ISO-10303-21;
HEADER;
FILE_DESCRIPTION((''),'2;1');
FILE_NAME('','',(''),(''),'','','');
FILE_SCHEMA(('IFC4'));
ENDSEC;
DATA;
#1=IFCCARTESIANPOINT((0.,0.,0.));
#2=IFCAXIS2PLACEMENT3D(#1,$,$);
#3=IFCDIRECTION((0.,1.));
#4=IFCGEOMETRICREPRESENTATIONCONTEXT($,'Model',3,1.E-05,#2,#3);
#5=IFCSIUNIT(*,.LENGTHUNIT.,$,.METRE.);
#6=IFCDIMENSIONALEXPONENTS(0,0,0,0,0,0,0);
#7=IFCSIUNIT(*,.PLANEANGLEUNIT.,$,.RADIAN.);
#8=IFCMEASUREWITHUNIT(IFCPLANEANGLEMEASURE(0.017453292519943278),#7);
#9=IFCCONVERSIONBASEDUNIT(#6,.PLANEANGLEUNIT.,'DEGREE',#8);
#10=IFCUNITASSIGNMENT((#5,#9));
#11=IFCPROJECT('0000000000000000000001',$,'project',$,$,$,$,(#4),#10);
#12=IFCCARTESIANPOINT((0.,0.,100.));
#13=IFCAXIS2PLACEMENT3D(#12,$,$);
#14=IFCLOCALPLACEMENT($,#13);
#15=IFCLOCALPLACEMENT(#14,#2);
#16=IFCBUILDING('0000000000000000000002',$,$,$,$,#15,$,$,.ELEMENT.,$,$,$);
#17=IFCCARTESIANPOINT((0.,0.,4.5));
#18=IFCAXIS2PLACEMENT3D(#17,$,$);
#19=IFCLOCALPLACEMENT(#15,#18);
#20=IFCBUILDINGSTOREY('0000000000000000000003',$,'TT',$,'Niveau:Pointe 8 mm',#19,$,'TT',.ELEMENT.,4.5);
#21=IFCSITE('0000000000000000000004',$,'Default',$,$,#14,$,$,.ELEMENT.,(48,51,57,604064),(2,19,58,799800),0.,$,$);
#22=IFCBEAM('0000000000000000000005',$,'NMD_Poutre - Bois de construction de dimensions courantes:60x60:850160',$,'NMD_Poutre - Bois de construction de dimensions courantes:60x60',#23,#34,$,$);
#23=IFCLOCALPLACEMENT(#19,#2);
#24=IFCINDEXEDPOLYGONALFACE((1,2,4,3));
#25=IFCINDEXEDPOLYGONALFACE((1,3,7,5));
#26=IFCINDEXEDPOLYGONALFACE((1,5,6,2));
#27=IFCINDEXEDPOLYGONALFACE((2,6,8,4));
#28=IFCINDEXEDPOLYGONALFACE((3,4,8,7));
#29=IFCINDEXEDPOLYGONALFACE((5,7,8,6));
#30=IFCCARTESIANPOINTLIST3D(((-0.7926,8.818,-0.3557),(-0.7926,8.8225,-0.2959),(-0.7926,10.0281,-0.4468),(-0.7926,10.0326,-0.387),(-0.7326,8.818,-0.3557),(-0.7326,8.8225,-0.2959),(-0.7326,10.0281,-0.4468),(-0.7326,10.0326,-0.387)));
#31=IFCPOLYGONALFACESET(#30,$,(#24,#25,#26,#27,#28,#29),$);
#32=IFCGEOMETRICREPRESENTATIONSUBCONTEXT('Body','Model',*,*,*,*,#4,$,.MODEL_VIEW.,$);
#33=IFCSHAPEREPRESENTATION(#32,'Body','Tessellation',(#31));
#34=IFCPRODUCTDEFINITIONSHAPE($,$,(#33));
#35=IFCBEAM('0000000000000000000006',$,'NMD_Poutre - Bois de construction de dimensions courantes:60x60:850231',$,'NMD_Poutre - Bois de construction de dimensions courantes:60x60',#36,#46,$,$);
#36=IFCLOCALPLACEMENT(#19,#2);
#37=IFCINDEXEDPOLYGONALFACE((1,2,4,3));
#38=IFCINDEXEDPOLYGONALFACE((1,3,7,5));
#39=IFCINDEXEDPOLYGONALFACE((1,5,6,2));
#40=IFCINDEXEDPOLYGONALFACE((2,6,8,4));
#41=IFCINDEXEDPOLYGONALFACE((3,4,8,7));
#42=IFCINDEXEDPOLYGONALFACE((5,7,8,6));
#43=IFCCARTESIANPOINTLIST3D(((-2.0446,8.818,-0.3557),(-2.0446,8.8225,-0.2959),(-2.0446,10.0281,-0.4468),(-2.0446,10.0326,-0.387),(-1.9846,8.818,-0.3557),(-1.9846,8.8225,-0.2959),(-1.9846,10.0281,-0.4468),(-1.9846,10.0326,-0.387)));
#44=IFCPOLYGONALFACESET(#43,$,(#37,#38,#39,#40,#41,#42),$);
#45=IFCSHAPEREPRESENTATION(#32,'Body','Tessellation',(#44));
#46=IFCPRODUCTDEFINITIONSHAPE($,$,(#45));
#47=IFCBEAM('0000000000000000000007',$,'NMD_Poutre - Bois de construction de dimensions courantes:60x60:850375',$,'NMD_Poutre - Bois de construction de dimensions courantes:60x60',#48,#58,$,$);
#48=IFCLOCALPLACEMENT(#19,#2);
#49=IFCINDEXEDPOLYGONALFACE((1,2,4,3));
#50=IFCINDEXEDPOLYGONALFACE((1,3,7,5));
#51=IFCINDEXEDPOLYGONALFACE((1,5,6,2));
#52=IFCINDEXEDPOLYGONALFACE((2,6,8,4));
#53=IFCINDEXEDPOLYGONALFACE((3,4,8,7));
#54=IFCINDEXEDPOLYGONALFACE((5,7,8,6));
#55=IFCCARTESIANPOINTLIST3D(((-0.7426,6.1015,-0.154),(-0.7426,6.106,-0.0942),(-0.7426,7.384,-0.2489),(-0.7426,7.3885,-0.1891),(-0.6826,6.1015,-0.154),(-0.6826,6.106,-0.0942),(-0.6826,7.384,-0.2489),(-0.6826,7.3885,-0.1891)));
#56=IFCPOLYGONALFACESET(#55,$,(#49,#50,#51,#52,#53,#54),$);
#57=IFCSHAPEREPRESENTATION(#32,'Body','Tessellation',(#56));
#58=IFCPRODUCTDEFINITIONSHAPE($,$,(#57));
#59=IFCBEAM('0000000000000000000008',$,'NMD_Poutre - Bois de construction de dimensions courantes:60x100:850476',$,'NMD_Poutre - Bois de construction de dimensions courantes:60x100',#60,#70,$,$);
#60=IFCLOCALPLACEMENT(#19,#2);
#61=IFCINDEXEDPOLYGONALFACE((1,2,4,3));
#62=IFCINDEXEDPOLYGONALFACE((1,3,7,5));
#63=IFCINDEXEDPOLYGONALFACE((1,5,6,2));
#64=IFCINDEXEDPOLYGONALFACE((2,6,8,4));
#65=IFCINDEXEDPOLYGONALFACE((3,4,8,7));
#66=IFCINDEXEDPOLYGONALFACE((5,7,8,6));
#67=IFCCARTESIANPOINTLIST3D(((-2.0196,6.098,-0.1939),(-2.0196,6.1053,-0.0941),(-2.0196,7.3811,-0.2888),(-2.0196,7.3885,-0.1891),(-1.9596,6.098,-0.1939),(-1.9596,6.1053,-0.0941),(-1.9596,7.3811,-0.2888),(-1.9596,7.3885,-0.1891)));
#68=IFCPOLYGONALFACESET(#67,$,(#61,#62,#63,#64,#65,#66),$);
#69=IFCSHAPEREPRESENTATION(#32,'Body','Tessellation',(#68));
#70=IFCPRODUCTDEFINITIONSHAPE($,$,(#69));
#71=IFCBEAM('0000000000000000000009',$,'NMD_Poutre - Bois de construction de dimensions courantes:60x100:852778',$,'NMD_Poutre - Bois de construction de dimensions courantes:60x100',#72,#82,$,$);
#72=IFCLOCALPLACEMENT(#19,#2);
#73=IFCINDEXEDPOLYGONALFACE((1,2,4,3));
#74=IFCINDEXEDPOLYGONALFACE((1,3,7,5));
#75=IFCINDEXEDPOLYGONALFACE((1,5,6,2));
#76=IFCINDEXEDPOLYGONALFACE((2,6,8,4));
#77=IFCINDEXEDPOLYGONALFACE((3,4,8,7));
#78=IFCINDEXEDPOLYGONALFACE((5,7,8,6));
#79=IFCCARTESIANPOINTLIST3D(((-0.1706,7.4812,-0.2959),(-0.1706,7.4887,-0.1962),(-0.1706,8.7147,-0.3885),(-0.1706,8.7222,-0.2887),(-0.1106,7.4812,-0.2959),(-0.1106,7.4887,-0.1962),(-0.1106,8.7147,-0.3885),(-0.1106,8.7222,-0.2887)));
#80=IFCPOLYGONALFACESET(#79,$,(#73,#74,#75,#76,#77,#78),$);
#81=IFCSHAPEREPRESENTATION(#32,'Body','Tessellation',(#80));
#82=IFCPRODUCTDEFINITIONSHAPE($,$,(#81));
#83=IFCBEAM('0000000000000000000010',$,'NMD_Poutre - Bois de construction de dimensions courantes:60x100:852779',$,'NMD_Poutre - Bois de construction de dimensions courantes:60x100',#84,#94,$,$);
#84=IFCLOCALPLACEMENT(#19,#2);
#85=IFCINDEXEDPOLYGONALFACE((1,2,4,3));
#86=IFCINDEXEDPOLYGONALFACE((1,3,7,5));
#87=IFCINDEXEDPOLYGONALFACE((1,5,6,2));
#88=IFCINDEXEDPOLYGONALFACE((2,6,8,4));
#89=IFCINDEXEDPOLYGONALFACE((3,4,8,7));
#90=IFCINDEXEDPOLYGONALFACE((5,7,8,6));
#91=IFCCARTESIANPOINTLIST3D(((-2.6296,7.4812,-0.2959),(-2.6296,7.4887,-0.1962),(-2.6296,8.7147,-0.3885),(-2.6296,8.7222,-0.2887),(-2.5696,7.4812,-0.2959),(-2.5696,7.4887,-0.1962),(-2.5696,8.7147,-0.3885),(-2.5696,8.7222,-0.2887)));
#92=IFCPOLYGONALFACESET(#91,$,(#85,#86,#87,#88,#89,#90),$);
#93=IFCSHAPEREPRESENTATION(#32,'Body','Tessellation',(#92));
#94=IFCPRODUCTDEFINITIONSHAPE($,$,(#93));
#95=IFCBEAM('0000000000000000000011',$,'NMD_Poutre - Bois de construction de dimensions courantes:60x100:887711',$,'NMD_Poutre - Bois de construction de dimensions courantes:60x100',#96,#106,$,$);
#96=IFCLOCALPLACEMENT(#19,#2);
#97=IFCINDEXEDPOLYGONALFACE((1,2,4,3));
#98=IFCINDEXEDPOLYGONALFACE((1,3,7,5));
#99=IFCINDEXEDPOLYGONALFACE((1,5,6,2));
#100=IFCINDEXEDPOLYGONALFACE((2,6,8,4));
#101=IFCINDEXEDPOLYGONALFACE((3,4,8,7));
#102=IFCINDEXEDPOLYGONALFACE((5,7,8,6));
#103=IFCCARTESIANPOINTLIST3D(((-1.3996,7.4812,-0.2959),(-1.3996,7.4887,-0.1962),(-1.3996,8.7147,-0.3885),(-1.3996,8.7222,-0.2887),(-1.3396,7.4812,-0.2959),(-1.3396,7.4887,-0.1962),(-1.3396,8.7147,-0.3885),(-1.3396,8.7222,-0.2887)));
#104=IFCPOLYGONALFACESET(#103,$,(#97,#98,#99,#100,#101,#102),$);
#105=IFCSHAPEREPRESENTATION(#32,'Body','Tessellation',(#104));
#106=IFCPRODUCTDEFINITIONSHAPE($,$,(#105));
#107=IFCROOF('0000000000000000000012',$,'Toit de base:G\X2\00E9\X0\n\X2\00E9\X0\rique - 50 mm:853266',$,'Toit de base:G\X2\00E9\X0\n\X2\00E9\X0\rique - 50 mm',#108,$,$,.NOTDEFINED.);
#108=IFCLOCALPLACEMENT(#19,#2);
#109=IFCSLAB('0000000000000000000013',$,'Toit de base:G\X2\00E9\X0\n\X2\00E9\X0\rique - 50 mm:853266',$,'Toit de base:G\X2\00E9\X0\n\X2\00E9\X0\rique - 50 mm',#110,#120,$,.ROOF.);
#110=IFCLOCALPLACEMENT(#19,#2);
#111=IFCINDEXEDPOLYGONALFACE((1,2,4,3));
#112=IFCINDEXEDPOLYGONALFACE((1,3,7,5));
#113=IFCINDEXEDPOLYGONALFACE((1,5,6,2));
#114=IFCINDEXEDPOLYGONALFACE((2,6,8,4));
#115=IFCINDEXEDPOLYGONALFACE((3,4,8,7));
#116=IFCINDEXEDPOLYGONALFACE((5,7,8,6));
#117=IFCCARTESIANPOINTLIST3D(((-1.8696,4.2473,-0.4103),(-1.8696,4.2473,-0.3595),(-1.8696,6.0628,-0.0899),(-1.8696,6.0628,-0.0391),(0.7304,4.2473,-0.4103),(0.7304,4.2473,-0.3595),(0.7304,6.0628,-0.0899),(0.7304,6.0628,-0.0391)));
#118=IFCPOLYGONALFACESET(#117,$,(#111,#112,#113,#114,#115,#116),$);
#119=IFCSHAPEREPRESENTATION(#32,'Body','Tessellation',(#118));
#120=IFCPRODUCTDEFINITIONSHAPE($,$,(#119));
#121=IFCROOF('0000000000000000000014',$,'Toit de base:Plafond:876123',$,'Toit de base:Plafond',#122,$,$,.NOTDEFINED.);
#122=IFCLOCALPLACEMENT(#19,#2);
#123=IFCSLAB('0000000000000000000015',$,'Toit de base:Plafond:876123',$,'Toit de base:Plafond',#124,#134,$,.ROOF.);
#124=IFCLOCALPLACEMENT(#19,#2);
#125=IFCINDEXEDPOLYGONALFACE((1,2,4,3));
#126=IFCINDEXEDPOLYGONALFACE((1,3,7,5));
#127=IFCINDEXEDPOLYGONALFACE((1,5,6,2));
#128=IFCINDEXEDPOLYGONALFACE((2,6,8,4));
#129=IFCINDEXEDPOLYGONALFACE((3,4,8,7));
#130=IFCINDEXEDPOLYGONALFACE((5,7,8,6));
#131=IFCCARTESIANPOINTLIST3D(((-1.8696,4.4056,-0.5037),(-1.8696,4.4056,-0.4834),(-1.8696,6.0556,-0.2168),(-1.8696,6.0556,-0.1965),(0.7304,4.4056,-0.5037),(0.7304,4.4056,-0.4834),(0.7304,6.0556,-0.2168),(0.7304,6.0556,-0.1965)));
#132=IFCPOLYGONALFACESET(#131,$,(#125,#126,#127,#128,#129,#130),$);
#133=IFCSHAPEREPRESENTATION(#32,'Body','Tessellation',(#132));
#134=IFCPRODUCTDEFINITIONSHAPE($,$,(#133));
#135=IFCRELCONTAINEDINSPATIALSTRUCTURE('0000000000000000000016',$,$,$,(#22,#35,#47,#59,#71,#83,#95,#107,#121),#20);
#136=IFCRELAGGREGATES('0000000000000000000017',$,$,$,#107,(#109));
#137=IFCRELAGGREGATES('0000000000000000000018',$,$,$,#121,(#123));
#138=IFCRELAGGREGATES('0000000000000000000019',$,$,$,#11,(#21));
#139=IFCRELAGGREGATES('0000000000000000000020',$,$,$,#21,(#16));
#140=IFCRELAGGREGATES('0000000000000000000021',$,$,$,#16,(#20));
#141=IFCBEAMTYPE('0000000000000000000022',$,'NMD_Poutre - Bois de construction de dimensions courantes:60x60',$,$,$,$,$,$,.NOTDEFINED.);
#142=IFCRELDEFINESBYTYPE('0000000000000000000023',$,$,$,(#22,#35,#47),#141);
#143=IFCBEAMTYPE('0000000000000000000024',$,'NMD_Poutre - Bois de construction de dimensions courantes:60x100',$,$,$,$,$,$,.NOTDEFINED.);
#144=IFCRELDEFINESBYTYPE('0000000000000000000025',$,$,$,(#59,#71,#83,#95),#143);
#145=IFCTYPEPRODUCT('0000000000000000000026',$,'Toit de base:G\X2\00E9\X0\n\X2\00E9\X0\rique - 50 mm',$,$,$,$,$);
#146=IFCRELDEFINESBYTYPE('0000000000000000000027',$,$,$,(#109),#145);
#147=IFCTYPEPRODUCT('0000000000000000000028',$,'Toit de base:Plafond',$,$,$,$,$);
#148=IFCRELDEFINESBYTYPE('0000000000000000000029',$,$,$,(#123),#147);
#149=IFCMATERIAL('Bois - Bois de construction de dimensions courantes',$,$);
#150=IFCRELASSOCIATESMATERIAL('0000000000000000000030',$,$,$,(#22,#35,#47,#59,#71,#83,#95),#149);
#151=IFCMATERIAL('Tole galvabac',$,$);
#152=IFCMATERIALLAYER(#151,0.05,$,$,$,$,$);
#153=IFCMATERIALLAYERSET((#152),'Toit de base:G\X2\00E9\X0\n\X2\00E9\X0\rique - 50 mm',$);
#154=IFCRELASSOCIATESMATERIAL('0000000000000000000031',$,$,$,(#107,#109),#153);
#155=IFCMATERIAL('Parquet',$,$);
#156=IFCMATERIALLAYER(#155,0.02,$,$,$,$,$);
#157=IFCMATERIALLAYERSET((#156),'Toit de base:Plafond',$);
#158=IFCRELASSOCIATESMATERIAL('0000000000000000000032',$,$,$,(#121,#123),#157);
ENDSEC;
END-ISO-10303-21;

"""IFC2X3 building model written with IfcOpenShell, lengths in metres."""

from ifc_helpers import new_model, entity, si_unit, converted_unit, direction, frame, frame_2d, origin, place, context, subcontext, project, spatial, rectangle, extrude, material, layer, layer_set, type_object, element, aggregate, save


model = new_model("IFC2X3")

# Units and contexts
model_context = context("Model", 3, precision=1e-05, world=origin(), true_north=direction((0.0, 1.0)))
body_context = subcontext(model_context, "Body", "Model", "MODEL_VIEW")
ifc_project = project(units=[si_unit("LENGTHUNIT", "METRE"), converted_unit("PLANEANGLEUNIT", "DEGREE", entity("IfcPlaneAngleMeasure", 0.017453292519943278), si_unit("PLANEANGLEUNIT", "RADIAN"), dimensions=[0, 0, 0, 0, 0, 0, 0])], contexts=[model_context])

# Site, building, storey
site_placement = place(None, frame((0.0, 0.0, 100.0)))
site = spatial("IfcSite", under=ifc_project, at=site_placement, Name="Default", CompositionType="ELEMENT", RefLatitude=(48, 51, 57, 604064), RefLongitude=(2, 19, 58, 799800), RefElevation=0.0)
building_placement = place(site_placement, origin())
building = spatial("IfcBuilding", under=site, at=building_placement, CompositionType="ELEMENT")
storey_placement = place(building_placement, frame((0.0, 0.0, 4.5)))
storey = spatial("IfcBuildingStorey", under=building, at=storey_placement, Name="TT", ObjectType="Niveau:Pointe 8 mm", LongName="TT", CompositionType="ELEMENT", Elevation=4.5)

# Beams
ifc_material_1 = material(Name="Bois - Bois de construction de dimensions courantes")
beam_type_1 = type_object("IfcBeamType", Name="NMD_Poutre - Bois de construction de dimensions courantes:60x60", PredefinedType="NOTDEFINED")
beam_1_placement = place(storey_placement, frame((-0.7626, 10.0792, -0.3905), z_axis=(0.0, 0.075069, 0.997178), x_axis=(0.0, -0.997178, 0.075069)))
element("IfcBeam", 1, at=beam_1_placement, inside=storey, type_object=beam_type_1, material=ifc_material_1, Name="NMD_Poutre - Bois de construction de dimensions courantes:60x60:850160", ObjectType="NMD_Poutre - Bois de construction de dimensions courantes:60x60", context=body_context, shape_type="SweptSolid", body=[
    extrude(rectangle(XDim=0.06, YDim=0.06, at=frame_2d((0.0, 0.0), x_axis=(1.0, 0.0))), frame((0.0467, 0.0, -0.03), z_axis=(1.0, 0.0, 0.0), x_axis=(0.0, 0.0, -1.0)), (0.0, 0.0, 1.0), 1.2136),
])
beam_2_placement = place(storey_placement, frame((-2.0146, 10.0792, -0.3905), z_axis=(0.0, 0.075069, 0.997178), x_axis=(0.0, -0.997178, 0.075069)))
element("IfcBeam", 2, at=beam_2_placement, inside=storey, type_object=beam_type_1, material=ifc_material_1, Name="NMD_Poutre - Bois de construction de dimensions courantes:60x60:850231", ObjectType="NMD_Poutre - Bois de construction de dimensions courantes:60x60", context=body_context, shape_type="SweptSolid", body=[
    extrude(rectangle(XDim=0.06, YDim=0.06, at=frame_2d((0.0, 0.0), x_axis=(1.0, 0.0))), frame((0.0467, 0.0, -0.03), z_axis=(1.0, 0.0, 0.0), x_axis=(0.0, 0.0, -1.0)), (0.0, 0.0, 1.0), 1.2136),
])
beam_3_placement = place(storey_placement, frame((-0.7126, 7.3888, -0.1891), z_axis=(0.0, 0.07378, 0.997275), x_axis=(0.0, -0.997275, 0.07378)))
element("IfcBeam", 3, at=beam_3_placement, inside=storey, type_object=beam_type_1, material=ifc_material_1, Name="NMD_Poutre - Bois de construction de dimensions courantes:60x60:850375", ObjectType="NMD_Poutre - Bois de construction de dimensions courantes:60x60", context=body_context, shape_type="SweptSolid", body=[
    extrude(rectangle(XDim=0.06, YDim=0.06, at=frame_2d((0.0, 0.0), x_axis=(1.0, 0.0))), frame((0.0004, 0.0, -0.03), z_axis=(1.0, 0.0, 0.0), x_axis=(0.0, 0.0, -1.0)), (0.0, 0.0, 1.0), 1.286),
])
beam_type_2 = type_object("IfcBeamType", Name="NMD_Poutre - Bois de construction de dimensions courantes:60x100", PredefinedType="NOTDEFINED")
beam_4_placement = place(storey_placement, frame((-1.9896, 7.3888, -0.1891), z_axis=(0.0, 0.07378, 0.997275), x_axis=(0.0, -0.997275, 0.07378)))
element("IfcBeam", 4, at=beam_4_placement, inside=storey, type_object=beam_type_2, material=ifc_material_1, Name="NMD_Poutre - Bois de construction de dimensions courantes:60x100:850476", ObjectType="NMD_Poutre - Bois de construction de dimensions courantes:60x100", context=body_context, shape_type="SweptSolid", body=[
    extrude(rectangle(XDim=0.1, YDim=0.06, at=frame_2d((0.0, 0.0), x_axis=(1.0, 0.0))), frame((0.0004, 0.0, -0.05), z_axis=(1.0, 0.0, 0.0), x_axis=(0.0, 0.0, -1.0)), (0.0, 0.0, 1.0), 1.2866),
])
beam_5_placement = place(storey_placement, frame((-0.1406, 8.7224, -0.2888), z_axis=(0.0, 0.07479, 0.997199), x_axis=(0.0, -0.997199, 0.07479)))
element("IfcBeam", 5, at=beam_5_placement, inside=storey, type_object=beam_type_2, material=ifc_material_1, Name="NMD_Poutre - Bois de construction de dimensions courantes:60x100:852778", ObjectType="NMD_Poutre - Bois de construction de dimensions courantes:60x100", context=body_context, shape_type="SweptSolid", body=[
    extrude(rectangle(XDim=0.1, YDim=0.06, at=frame_2d((0.0, 0.0), x_axis=(1.0, 0.0))), frame((0.0002, 0.0, -0.05), z_axis=(1.0, 0.0, 0.0), x_axis=(0.0, 0.0, -1.0)), (0.0, 0.0, 1.0), 1.237),
])
beam_6_placement = place(storey_placement, frame((-2.5996, 8.7224, -0.2888), z_axis=(0.0, 0.07479, 0.997199), x_axis=(0.0, -0.997199, 0.07479)))
element("IfcBeam", 6, at=beam_6_placement, inside=storey, type_object=beam_type_2, material=ifc_material_1, Name="NMD_Poutre - Bois de construction de dimensions courantes:60x100:852779", ObjectType="NMD_Poutre - Bois de construction de dimensions courantes:60x100", context=body_context, shape_type="SweptSolid", body=[
    extrude(rectangle(XDim=0.1, YDim=0.06, at=frame_2d((0.0, 0.0), x_axis=(1.0, 0.0))), frame((0.0002, 0.0, -0.05), z_axis=(1.0, 0.0, 0.0), x_axis=(0.0, 0.0, -1.0)), (0.0, 0.0, 1.0), 1.237),
])
beam_7_placement = place(storey_placement, frame((-1.3696, 8.7224, -0.2888), z_axis=(0.0, 0.07479, 0.997199), x_axis=(0.0, -0.997199, 0.07479)))
element("IfcBeam", 7, at=beam_7_placement, inside=storey, type_object=beam_type_2, material=ifc_material_1, Name="NMD_Poutre - Bois de construction de dimensions courantes:60x100:887711", ObjectType="NMD_Poutre - Bois de construction de dimensions courantes:60x100", context=body_context, shape_type="SweptSolid", body=[
    extrude(rectangle(XDim=0.1, YDim=0.06, at=frame_2d((0.0, 0.0), x_axis=(1.0, 0.0))), frame((0.0002, 0.0, -0.05), z_axis=(1.0, 0.0, 0.0), x_axis=(0.0, 0.0, -1.0)), (0.0, 0.0, 1.0), 1.237),
])

# Roofs, slabs
ifc_material_2 = material(Name="Tole galvabac")
ifc_layer_1 = layer(ifc_material_2, 0.05)
ifc_layer_set_1 = layer_set([ifc_layer_1], Name="Toit de base:Générique - 50 mm")
roof_1_placement = place(storey_placement, frame((-1.8696, 4.2473, -0.4103)))
roof_1 = element("IfcRoof", 8, at=roof_1_placement, inside=storey, material=ifc_layer_set_1, Name="Toit de base:Générique - 50 mm:853266", ObjectType="Toit de base:Générique - 50 mm", ShapeType="NOTDEFINED")
type_product_1 = type_object("IfcTypeProduct", Name="Toit de base:Générique - 50 mm")
slab_1_placement = place(roof_1_placement, origin())
slab_1 = element("IfcSlab", 9, at=slab_1_placement, type_object=type_product_1, material=ifc_layer_set_1, Name="Toit de base:Générique - 50 mm:853266", ObjectType="Toit de base:Générique - 50 mm", PredefinedType="ROOF", context=body_context, shape_type="SweptSolid", body=[
    extrude(rectangle(XDim=2.6, YDim=1.8435, at=frame_2d((0.0, 0.0), x_axis=(1.0, 0.0))), frame((1.3, 0.9077, 0.1602), z_axis=(0.0, -0.173785, 0.984784), x_axis=(1.0, 0.0, 0.0)), (0.0, 0.173785, 0.984784), 0.0508),
])
aggregate(roof_1, [slab_1])
ifc_material_3 = material(Name="Parquet")
ifc_layer_2 = layer(ifc_material_3, 0.02)
ifc_layer_set_2 = layer_set([ifc_layer_2], Name="Toit de base:Plafond")
roof_2_placement = place(storey_placement, frame((-1.8696, 4.4056, -0.5037)))
roof_2 = element("IfcRoof", 10, at=roof_2_placement, inside=storey, material=ifc_layer_set_2, Name="Toit de base:Plafond:876123", ObjectType="Toit de base:Plafond", ShapeType="NOTDEFINED")
type_product_2 = type_object("IfcTypeProduct", Name="Toit de base:Plafond")
slab_2_placement = place(roof_2_placement, origin())
slab_2 = element("IfcSlab", 11, at=slab_2_placement, type_object=type_product_2, material=ifc_layer_set_2, Name="Toit de base:Plafond:876123", ObjectType="Toit de base:Plafond", PredefinedType="ROOF", context=body_context, shape_type="SweptSolid", body=[
    extrude(rectangle(XDim=2.6, YDim=1.6748, at=frame_2d((0.0, 0.0), x_axis=(1.0, 0.0))), frame((1.3, 0.825, 0.1435), z_axis=(0.0, -0.171316, 0.985216), x_axis=(1.0, 0.0, 0.0)), (0.0, 0.171316, 0.985216), 0.0203),
])
aggregate(roof_2, [slab_2])

save(model, "model.ifc")
